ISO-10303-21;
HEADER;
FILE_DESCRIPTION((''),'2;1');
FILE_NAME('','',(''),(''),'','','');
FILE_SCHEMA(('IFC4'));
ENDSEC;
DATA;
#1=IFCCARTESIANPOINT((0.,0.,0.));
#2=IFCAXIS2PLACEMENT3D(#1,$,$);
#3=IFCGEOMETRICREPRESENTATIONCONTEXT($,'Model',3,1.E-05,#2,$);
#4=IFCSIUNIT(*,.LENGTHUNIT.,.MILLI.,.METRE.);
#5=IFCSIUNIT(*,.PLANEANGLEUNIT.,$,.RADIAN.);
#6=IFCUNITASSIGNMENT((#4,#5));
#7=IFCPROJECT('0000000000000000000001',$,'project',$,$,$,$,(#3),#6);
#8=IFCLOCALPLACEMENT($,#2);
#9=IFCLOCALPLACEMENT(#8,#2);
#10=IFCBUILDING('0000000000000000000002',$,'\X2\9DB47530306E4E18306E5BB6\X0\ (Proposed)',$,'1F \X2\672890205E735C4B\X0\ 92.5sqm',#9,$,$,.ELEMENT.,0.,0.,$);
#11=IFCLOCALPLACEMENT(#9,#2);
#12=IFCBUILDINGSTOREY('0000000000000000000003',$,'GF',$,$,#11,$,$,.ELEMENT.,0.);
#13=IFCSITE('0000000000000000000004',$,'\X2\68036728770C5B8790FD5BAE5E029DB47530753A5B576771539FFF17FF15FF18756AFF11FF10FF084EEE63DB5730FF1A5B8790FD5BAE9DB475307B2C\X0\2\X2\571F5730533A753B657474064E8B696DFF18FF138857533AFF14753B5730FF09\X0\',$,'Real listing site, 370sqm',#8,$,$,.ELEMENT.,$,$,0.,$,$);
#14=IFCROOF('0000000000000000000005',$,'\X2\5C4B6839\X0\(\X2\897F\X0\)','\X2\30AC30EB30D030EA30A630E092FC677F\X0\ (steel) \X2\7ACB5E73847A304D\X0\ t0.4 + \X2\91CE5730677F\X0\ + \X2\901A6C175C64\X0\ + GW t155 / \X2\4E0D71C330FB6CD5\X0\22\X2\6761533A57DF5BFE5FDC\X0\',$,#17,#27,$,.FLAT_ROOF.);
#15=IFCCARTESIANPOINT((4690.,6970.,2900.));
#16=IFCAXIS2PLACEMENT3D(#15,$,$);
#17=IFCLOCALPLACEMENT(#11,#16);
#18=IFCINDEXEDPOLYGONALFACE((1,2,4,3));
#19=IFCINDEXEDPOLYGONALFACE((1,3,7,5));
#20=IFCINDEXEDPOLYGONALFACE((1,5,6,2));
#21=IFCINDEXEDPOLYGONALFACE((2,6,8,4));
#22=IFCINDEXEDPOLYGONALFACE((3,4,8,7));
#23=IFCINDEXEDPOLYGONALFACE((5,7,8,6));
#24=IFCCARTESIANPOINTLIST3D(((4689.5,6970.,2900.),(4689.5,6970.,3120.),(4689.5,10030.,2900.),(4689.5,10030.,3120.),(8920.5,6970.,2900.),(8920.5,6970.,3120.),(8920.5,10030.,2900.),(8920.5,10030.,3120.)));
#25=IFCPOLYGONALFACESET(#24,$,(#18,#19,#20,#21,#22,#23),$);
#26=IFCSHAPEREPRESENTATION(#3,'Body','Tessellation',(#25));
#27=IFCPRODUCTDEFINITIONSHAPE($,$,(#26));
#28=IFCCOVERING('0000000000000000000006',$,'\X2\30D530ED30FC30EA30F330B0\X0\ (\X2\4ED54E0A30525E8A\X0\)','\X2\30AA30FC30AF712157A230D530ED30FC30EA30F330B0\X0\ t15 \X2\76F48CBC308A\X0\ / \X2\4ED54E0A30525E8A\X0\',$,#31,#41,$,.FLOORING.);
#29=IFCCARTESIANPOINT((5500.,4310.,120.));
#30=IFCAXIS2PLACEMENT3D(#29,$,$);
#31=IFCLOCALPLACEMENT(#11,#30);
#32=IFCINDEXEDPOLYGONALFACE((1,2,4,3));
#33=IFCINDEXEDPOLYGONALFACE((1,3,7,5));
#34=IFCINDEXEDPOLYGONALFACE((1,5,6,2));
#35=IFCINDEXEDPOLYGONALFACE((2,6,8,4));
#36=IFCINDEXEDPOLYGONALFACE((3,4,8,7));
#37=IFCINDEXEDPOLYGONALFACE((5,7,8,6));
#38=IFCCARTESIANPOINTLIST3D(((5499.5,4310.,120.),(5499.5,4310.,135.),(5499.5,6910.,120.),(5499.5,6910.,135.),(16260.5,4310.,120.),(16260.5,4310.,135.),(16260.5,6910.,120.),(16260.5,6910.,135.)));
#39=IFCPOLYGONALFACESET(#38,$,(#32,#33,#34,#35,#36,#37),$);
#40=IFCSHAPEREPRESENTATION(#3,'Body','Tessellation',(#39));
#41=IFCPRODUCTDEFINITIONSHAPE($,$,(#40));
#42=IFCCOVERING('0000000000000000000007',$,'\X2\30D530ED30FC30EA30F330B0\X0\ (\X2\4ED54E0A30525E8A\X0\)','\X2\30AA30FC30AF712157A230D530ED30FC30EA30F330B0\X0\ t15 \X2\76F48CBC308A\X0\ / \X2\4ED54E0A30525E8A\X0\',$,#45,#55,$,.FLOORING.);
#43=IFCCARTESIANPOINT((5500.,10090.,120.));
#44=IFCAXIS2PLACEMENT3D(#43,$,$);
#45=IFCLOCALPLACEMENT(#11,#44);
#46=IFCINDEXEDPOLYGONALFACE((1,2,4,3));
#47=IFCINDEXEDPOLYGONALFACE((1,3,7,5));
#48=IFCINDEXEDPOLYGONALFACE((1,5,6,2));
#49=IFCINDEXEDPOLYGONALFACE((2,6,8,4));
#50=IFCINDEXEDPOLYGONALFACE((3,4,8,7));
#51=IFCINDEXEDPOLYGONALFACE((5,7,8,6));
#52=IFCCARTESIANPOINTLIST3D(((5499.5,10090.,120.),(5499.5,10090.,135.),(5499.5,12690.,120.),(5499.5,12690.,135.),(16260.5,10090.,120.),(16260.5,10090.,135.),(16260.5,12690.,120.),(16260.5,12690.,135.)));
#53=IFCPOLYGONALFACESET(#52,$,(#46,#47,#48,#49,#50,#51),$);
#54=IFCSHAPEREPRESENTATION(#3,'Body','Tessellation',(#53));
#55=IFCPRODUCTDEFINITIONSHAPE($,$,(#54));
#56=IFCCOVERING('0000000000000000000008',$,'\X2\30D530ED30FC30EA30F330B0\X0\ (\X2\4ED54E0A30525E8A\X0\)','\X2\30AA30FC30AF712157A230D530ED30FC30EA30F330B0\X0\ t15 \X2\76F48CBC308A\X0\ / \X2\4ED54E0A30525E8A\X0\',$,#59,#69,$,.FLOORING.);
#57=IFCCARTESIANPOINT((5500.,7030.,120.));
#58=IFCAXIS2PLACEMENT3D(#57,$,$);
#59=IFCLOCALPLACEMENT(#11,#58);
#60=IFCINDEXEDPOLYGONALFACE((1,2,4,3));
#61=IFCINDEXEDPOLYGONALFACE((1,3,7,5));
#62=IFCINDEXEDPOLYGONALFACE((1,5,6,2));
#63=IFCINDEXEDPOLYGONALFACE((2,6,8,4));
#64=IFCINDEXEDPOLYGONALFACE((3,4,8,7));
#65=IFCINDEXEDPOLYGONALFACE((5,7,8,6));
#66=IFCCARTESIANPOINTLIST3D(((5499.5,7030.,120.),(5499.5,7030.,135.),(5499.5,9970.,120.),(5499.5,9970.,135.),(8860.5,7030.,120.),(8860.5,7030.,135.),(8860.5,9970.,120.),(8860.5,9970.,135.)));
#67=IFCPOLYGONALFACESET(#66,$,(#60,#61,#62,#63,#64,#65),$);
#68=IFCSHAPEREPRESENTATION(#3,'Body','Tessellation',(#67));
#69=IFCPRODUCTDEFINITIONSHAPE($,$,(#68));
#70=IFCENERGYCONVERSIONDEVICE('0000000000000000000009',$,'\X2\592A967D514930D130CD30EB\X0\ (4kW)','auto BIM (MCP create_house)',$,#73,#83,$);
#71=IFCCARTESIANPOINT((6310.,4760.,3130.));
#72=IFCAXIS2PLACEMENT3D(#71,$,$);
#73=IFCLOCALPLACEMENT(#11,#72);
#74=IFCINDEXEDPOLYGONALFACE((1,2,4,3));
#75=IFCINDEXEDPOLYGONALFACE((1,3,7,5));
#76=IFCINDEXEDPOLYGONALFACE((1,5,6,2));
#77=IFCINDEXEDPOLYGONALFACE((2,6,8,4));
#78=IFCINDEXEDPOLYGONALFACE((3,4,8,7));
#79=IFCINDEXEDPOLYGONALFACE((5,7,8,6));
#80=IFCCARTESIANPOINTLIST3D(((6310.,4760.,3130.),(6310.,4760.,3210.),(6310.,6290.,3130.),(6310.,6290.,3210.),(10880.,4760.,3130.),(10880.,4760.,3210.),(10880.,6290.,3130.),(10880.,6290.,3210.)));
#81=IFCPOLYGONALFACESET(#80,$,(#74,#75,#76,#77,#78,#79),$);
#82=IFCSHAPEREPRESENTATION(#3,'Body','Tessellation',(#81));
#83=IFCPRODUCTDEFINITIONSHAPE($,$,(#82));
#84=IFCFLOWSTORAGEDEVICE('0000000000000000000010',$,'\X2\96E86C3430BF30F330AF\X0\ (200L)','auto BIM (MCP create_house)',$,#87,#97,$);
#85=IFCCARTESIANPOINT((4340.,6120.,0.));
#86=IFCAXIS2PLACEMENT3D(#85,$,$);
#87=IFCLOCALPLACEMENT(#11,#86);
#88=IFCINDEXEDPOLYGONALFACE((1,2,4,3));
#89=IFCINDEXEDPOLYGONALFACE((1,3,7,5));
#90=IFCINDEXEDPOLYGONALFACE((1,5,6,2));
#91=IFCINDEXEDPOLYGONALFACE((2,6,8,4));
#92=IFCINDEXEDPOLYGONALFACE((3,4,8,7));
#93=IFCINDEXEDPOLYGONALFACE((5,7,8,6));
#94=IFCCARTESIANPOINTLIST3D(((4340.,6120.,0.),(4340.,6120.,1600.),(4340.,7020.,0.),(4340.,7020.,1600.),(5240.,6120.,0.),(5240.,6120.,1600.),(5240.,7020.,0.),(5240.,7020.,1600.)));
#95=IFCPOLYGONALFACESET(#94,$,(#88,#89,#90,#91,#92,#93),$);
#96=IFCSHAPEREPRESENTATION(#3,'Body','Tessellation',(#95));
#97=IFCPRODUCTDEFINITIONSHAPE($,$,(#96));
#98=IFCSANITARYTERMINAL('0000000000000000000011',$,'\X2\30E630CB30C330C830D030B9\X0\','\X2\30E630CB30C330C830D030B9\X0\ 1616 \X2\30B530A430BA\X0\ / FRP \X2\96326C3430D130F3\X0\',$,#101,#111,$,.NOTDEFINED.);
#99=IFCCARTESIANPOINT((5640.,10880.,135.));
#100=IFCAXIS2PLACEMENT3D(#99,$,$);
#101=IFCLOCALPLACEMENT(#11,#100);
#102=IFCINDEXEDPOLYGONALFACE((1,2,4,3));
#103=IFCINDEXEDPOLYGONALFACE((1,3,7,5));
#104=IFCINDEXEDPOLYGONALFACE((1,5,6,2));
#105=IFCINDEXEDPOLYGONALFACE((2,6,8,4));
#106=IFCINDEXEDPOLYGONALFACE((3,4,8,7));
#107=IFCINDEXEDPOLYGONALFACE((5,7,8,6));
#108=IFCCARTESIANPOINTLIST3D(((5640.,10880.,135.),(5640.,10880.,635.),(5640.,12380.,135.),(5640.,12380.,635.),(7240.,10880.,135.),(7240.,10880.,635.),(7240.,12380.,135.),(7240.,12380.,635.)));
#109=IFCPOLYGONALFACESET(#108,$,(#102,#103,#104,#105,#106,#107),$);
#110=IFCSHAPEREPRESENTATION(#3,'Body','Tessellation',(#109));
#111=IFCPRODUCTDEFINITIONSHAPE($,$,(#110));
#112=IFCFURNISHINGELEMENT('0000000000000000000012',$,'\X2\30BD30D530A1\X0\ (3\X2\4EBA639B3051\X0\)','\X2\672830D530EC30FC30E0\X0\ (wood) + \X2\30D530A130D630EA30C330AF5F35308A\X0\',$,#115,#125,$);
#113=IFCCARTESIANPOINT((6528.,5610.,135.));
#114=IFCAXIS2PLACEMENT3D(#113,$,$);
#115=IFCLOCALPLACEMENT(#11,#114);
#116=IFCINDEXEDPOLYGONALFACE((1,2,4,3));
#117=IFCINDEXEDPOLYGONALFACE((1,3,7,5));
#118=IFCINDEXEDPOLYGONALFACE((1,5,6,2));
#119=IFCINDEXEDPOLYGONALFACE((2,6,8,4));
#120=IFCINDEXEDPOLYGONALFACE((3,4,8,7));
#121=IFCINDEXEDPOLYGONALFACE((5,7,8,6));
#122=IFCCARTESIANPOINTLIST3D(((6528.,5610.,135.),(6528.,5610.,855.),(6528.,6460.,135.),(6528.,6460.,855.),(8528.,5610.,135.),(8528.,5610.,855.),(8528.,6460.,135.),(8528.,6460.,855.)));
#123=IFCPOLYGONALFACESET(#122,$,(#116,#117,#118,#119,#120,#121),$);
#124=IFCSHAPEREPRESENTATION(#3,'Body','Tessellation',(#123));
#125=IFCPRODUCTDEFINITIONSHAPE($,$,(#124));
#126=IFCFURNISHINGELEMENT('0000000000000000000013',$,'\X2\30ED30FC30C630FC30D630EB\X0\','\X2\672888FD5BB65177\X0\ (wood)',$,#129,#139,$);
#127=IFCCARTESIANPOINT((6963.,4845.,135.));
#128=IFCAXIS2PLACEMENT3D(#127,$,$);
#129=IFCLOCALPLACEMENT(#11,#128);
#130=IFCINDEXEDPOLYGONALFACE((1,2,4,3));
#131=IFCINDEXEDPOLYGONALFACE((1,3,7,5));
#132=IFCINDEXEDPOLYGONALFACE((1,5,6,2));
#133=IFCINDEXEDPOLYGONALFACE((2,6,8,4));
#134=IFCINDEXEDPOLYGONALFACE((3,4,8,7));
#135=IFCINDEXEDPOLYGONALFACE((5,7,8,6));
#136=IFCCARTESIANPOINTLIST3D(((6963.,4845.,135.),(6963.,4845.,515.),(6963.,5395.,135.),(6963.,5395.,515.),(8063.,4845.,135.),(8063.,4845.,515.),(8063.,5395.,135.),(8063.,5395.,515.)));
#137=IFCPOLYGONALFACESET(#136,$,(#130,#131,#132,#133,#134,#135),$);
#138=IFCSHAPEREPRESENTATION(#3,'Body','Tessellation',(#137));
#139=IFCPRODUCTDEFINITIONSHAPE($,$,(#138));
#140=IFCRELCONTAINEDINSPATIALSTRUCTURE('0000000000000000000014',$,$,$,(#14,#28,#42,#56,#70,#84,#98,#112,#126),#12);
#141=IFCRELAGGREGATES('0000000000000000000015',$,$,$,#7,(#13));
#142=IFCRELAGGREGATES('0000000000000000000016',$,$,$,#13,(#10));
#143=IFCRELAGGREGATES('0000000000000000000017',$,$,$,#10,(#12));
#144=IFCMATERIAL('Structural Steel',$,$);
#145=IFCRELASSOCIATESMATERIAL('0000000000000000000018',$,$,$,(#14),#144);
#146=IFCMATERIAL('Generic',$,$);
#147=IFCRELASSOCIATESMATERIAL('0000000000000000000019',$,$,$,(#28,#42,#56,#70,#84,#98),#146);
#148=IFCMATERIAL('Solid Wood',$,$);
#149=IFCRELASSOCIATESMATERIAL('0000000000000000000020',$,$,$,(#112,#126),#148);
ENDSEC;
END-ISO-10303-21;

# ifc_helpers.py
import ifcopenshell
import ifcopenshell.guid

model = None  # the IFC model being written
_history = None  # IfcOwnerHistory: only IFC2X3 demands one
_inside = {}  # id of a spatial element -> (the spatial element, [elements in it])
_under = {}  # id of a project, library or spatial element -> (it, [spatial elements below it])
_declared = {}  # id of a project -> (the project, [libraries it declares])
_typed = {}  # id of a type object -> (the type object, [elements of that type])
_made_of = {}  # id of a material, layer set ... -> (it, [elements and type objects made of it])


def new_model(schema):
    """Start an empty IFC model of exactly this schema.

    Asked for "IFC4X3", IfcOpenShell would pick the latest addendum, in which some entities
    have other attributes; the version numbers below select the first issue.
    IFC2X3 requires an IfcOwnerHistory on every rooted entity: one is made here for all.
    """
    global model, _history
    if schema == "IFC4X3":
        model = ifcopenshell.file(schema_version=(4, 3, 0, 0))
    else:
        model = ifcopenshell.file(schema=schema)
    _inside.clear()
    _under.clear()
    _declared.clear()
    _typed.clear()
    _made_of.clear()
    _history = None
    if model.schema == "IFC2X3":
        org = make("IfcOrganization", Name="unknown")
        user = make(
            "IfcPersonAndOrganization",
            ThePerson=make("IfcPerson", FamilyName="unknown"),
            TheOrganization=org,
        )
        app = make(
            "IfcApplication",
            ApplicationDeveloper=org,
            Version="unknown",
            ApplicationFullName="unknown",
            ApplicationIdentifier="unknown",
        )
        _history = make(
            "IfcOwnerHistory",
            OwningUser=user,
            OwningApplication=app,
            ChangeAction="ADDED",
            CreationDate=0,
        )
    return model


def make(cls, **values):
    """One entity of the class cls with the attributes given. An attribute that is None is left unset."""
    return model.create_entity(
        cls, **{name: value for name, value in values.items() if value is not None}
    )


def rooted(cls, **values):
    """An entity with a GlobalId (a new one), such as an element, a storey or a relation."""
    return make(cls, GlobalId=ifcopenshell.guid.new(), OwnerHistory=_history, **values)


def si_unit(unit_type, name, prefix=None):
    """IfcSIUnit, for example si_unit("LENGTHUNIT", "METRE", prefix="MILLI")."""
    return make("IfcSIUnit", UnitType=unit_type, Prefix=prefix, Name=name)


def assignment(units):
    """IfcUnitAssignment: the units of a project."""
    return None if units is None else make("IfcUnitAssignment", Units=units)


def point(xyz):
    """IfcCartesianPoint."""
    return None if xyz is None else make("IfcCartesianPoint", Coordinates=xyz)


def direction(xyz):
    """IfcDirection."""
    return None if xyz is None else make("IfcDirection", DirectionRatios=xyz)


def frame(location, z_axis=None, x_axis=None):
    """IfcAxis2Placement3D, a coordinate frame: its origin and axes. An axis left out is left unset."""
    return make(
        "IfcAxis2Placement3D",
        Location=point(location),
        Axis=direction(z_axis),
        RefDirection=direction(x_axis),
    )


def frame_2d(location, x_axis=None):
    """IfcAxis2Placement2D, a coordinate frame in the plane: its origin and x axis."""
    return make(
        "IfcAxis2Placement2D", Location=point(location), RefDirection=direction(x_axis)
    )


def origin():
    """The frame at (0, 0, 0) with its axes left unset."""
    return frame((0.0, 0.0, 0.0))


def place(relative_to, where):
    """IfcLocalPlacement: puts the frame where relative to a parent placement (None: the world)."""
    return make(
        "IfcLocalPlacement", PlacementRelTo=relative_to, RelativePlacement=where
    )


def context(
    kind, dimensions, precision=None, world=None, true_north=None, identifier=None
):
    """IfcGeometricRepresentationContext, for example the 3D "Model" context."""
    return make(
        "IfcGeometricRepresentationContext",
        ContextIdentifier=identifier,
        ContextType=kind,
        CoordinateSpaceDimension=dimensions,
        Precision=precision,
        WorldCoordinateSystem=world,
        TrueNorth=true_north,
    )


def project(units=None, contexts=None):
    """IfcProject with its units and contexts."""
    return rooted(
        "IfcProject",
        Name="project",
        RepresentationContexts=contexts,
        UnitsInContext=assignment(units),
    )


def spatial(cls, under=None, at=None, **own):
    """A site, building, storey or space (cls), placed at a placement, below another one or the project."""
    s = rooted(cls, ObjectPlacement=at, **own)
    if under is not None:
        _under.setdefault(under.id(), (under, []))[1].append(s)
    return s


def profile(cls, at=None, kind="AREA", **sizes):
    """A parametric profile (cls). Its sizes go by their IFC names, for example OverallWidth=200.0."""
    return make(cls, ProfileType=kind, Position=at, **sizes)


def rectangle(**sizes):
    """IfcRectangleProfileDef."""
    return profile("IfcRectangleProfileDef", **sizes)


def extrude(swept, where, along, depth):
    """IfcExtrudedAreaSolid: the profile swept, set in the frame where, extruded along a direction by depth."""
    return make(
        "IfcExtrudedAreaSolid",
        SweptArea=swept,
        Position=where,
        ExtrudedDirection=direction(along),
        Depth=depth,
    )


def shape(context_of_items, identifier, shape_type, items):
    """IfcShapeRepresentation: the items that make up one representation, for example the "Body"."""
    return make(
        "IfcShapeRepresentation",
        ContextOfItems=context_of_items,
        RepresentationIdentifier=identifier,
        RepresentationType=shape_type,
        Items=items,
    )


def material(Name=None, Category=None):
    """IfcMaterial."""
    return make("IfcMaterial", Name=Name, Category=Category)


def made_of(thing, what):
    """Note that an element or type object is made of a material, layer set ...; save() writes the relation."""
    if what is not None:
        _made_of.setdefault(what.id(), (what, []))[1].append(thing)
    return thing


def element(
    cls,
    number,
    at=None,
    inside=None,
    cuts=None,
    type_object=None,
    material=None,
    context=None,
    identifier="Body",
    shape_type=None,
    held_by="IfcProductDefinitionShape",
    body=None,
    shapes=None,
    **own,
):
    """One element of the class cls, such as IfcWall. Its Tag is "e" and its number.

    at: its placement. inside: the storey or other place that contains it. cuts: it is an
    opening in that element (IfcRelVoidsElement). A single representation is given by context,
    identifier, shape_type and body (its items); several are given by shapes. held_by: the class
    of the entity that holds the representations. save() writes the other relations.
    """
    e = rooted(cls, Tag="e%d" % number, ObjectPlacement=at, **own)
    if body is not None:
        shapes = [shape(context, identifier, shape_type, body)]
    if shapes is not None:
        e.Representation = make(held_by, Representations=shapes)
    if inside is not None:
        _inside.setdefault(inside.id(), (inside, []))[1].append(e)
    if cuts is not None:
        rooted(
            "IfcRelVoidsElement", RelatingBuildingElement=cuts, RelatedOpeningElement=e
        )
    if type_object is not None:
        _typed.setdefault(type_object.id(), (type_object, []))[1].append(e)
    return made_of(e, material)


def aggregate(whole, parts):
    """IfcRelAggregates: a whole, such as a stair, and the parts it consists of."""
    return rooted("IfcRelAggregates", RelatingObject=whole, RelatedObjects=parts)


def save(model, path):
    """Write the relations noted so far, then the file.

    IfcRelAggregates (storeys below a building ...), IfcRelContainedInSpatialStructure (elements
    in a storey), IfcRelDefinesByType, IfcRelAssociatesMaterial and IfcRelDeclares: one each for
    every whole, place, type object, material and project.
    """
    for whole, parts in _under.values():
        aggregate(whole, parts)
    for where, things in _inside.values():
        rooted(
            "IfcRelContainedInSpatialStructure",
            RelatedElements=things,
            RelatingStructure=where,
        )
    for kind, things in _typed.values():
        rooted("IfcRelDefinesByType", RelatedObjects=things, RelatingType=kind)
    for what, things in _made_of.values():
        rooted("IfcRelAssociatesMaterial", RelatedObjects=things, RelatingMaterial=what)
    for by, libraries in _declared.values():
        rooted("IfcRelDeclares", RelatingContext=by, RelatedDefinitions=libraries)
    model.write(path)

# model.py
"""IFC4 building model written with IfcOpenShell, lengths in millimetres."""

from ifc_helpers import new_model, si_unit, frame, frame_2d, origin, place, context, project, spatial, rectangle, extrude, material, element, save


model = new_model("IFC4")

# Units and contexts
model_context = context("Model", 3, precision=1e-05, world=origin())
ifc_project = project(units=[si_unit("LENGTHUNIT", "METRE", prefix="MILLI"), si_unit("PLANEANGLEUNIT", "RADIAN")], contexts=[model_context])

# Site, building, storey
site_placement = place(None, origin())
site = spatial("IfcSite", under=ifc_project, at=site_placement, Name="栃木県宇都宮市鶴田町字東原７５８番１０（仮換地：宇都宮鶴田第2土地区画整理事業８３街区４画地）", ObjectType="Real listing site, 370sqm", CompositionType="ELEMENT", RefElevation=0.0)
building_placement = place(site_placement, origin())
building = spatial("IfcBuilding", under=site, at=building_placement, Name="鶴田の丘の家 (Proposed)", ObjectType="1F 木造平屋 92.5sqm", CompositionType="ELEMENT", ElevationOfRefHeight=0.0, ElevationOfTerrain=0.0)
storey_placement = place(building_placement, origin())
storey = spatial("IfcBuildingStorey", under=building, at=storey_placement, Name="GF", CompositionType="ELEMENT", Elevation=0.0)

# Shared definitions
ifc_material_1 = material(Name="Solid Wood")

# Roof
ifc_material_2 = material(Name="Structural Steel")
roof_1_placement = place(storey_placement, frame((4690.0, 6970.0, 2900.0)))
element("IfcRoof", 1, at=roof_1_placement, inside=storey, material=ifc_material_2, Name="屋根(西)", Description="ガルバリウム鋼板 (steel) 立平葺き t0.4 + 野地板 + 通気層 + GW t155 / 不燃・法22条区域対応", PredefinedType="FLAT_ROOF", context=model_context, shape_type="SweptSolid", body=[
    extrude(rectangle(XDim=4231.0, YDim=3060.0, at=frame_2d((2115.0, 1530.0))), frame((4690.0, 6970.0, 2900.0)), (0.0, 0.0, 1.0), 220.0),
])

# Coverings
ifc_material_3 = material(Name="Generic")
covering_1_placement = place(storey_placement, frame((5500.0, 4310.0, 120.0)))
element("IfcCovering", 2, at=covering_1_placement, inside=storey, material=ifc_material_3, Name="フローリング (仕上げ床)", Description="オーク無垢フローリング t15 直貼り / 仕上げ床", PredefinedType="FLOORING", context=model_context, shape_type="SweptSolid", body=[
    extrude(rectangle(XDim=10761.0, YDim=2600.0, at=frame_2d((5380.0, 1300.0))), frame((5500.0, 4310.0, 120.0)), (0.0, 0.0, 1.0), 15.0),
])
covering_2_placement = place(storey_placement, frame((5500.0, 10090.0, 120.0)))
element("IfcCovering", 3, at=covering_2_placement, inside=storey, material=ifc_material_3, Name="フローリング (仕上げ床)", Description="オーク無垢フローリング t15 直貼り / 仕上げ床", PredefinedType="FLOORING", context=model_context, shape_type="SweptSolid", body=[
    extrude(rectangle(XDim=10761.0, YDim=2600.0, at=frame_2d((5380.0, 1300.0))), frame((5500.0, 10090.0, 120.0)), (0.0, 0.0, 1.0), 15.0),
])
covering_3_placement = place(storey_placement, frame((5500.0, 7030.0, 120.0)))
element("IfcCovering", 4, at=covering_3_placement, inside=storey, material=ifc_material_3, Name="フローリング (仕上げ床)", Description="オーク無垢フローリング t15 直貼り / 仕上げ床", PredefinedType="FLOORING", context=model_context, shape_type="SweptSolid", body=[
    extrude(rectangle(XDim=3361.0, YDim=2940.0, at=frame_2d((1680.0, 1470.0))), frame((5500.0, 7030.0, 120.0)), (0.0, 0.0, 1.0), 15.0),
])

# Energy conversion device
energy_conversion_device_placement = place(storey_placement, frame((6310.0, 4760.0, 3130.0)))
element("IfcEnergyConversionDevice", 5, at=energy_conversion_device_placement, inside=storey, material=ifc_material_3, Name="太陽光パネル (4kW)", Description="auto BIM (MCP create_house)", context=model_context, shape_type="SweptSolid", body=[
    extrude(rectangle(XDim=4570.0, YDim=1530.0, at=frame_2d((2285.0, 765.0))), frame((6310.0, 4760.0, 3130.0)), (0.0, 0.0, 1.0), 80.0),
])

# Flow storage device
flow_storage_device_placement = place(storey_placement, frame((4340.0, 6120.0, 0.0)))
element("IfcFlowStorageDevice", 6, at=flow_storage_device_placement, inside=storey, material=ifc_material_3, Name="雨水タンク (200L)", Description="auto BIM (MCP create_house)", context=model_context, shape_type="SweptSolid", body=[
    extrude(rectangle(XDim=900.0, YDim=900.0, at=frame_2d((450.0, 450.0))), frame((4340.0, 6120.0, 0.0)), (0.0, 0.0, 1.0), 1600.0),
])

# Sanitary terminal
sanitary_terminal_placement = place(storey_placement, frame((5640.0, 10880.0, 135.0)))
element("IfcSanitaryTerminal", 7, at=sanitary_terminal_placement, inside=storey, material=ifc_material_3, Name="ユニットバス", Description="ユニットバス 1616 サイズ / FRP 防水パン", PredefinedType="NOTDEFINED", context=model_context, shape_type="SweptSolid", body=[
    extrude(rectangle(XDim=1600.0, YDim=1500.0, at=frame_2d((800.0, 750.0))), frame((5640.0, 10880.0, 135.0)), (0.0, 0.0, 1.0), 500.0),
])

# Furnishing elements
furnishing_1_placement = place(storey_placement, frame((6528.0, 5610.0, 135.0)))
element("IfcFurnishingElement", 8, at=furnishing_1_placement, inside=storey, material=ifc_material_1, Name="ソファ (3人掛け)", Description="木フレーム (wood) + ファブリック張り", context=model_context, shape_type="SweptSolid", body=[
    extrude(rectangle(XDim=2000.0, YDim=850.0, at=frame_2d((1000.0, 425.0))), frame((6528.0, 5610.0, 135.0)), (0.0, 0.0, 1.0), 720.0),
])
furnishing_2_placement = place(storey_placement, frame((6963.0, 4845.0, 135.0)))
element("IfcFurnishingElement", 9, at=furnishing_2_placement, inside=storey, material=ifc_material_1, Name="ローテーブル", Description="木製家具 (wood)", context=model_context, shape_type="SweptSolid", body=[
    extrude(rectangle(XDim=1100.0, YDim=550.0, at=frame_2d((550.0, 275.0))), frame((6963.0, 4845.0, 135.0)), (0.0, 0.0, 1.0), 380.0),
])

save(model, "model.ifc")
